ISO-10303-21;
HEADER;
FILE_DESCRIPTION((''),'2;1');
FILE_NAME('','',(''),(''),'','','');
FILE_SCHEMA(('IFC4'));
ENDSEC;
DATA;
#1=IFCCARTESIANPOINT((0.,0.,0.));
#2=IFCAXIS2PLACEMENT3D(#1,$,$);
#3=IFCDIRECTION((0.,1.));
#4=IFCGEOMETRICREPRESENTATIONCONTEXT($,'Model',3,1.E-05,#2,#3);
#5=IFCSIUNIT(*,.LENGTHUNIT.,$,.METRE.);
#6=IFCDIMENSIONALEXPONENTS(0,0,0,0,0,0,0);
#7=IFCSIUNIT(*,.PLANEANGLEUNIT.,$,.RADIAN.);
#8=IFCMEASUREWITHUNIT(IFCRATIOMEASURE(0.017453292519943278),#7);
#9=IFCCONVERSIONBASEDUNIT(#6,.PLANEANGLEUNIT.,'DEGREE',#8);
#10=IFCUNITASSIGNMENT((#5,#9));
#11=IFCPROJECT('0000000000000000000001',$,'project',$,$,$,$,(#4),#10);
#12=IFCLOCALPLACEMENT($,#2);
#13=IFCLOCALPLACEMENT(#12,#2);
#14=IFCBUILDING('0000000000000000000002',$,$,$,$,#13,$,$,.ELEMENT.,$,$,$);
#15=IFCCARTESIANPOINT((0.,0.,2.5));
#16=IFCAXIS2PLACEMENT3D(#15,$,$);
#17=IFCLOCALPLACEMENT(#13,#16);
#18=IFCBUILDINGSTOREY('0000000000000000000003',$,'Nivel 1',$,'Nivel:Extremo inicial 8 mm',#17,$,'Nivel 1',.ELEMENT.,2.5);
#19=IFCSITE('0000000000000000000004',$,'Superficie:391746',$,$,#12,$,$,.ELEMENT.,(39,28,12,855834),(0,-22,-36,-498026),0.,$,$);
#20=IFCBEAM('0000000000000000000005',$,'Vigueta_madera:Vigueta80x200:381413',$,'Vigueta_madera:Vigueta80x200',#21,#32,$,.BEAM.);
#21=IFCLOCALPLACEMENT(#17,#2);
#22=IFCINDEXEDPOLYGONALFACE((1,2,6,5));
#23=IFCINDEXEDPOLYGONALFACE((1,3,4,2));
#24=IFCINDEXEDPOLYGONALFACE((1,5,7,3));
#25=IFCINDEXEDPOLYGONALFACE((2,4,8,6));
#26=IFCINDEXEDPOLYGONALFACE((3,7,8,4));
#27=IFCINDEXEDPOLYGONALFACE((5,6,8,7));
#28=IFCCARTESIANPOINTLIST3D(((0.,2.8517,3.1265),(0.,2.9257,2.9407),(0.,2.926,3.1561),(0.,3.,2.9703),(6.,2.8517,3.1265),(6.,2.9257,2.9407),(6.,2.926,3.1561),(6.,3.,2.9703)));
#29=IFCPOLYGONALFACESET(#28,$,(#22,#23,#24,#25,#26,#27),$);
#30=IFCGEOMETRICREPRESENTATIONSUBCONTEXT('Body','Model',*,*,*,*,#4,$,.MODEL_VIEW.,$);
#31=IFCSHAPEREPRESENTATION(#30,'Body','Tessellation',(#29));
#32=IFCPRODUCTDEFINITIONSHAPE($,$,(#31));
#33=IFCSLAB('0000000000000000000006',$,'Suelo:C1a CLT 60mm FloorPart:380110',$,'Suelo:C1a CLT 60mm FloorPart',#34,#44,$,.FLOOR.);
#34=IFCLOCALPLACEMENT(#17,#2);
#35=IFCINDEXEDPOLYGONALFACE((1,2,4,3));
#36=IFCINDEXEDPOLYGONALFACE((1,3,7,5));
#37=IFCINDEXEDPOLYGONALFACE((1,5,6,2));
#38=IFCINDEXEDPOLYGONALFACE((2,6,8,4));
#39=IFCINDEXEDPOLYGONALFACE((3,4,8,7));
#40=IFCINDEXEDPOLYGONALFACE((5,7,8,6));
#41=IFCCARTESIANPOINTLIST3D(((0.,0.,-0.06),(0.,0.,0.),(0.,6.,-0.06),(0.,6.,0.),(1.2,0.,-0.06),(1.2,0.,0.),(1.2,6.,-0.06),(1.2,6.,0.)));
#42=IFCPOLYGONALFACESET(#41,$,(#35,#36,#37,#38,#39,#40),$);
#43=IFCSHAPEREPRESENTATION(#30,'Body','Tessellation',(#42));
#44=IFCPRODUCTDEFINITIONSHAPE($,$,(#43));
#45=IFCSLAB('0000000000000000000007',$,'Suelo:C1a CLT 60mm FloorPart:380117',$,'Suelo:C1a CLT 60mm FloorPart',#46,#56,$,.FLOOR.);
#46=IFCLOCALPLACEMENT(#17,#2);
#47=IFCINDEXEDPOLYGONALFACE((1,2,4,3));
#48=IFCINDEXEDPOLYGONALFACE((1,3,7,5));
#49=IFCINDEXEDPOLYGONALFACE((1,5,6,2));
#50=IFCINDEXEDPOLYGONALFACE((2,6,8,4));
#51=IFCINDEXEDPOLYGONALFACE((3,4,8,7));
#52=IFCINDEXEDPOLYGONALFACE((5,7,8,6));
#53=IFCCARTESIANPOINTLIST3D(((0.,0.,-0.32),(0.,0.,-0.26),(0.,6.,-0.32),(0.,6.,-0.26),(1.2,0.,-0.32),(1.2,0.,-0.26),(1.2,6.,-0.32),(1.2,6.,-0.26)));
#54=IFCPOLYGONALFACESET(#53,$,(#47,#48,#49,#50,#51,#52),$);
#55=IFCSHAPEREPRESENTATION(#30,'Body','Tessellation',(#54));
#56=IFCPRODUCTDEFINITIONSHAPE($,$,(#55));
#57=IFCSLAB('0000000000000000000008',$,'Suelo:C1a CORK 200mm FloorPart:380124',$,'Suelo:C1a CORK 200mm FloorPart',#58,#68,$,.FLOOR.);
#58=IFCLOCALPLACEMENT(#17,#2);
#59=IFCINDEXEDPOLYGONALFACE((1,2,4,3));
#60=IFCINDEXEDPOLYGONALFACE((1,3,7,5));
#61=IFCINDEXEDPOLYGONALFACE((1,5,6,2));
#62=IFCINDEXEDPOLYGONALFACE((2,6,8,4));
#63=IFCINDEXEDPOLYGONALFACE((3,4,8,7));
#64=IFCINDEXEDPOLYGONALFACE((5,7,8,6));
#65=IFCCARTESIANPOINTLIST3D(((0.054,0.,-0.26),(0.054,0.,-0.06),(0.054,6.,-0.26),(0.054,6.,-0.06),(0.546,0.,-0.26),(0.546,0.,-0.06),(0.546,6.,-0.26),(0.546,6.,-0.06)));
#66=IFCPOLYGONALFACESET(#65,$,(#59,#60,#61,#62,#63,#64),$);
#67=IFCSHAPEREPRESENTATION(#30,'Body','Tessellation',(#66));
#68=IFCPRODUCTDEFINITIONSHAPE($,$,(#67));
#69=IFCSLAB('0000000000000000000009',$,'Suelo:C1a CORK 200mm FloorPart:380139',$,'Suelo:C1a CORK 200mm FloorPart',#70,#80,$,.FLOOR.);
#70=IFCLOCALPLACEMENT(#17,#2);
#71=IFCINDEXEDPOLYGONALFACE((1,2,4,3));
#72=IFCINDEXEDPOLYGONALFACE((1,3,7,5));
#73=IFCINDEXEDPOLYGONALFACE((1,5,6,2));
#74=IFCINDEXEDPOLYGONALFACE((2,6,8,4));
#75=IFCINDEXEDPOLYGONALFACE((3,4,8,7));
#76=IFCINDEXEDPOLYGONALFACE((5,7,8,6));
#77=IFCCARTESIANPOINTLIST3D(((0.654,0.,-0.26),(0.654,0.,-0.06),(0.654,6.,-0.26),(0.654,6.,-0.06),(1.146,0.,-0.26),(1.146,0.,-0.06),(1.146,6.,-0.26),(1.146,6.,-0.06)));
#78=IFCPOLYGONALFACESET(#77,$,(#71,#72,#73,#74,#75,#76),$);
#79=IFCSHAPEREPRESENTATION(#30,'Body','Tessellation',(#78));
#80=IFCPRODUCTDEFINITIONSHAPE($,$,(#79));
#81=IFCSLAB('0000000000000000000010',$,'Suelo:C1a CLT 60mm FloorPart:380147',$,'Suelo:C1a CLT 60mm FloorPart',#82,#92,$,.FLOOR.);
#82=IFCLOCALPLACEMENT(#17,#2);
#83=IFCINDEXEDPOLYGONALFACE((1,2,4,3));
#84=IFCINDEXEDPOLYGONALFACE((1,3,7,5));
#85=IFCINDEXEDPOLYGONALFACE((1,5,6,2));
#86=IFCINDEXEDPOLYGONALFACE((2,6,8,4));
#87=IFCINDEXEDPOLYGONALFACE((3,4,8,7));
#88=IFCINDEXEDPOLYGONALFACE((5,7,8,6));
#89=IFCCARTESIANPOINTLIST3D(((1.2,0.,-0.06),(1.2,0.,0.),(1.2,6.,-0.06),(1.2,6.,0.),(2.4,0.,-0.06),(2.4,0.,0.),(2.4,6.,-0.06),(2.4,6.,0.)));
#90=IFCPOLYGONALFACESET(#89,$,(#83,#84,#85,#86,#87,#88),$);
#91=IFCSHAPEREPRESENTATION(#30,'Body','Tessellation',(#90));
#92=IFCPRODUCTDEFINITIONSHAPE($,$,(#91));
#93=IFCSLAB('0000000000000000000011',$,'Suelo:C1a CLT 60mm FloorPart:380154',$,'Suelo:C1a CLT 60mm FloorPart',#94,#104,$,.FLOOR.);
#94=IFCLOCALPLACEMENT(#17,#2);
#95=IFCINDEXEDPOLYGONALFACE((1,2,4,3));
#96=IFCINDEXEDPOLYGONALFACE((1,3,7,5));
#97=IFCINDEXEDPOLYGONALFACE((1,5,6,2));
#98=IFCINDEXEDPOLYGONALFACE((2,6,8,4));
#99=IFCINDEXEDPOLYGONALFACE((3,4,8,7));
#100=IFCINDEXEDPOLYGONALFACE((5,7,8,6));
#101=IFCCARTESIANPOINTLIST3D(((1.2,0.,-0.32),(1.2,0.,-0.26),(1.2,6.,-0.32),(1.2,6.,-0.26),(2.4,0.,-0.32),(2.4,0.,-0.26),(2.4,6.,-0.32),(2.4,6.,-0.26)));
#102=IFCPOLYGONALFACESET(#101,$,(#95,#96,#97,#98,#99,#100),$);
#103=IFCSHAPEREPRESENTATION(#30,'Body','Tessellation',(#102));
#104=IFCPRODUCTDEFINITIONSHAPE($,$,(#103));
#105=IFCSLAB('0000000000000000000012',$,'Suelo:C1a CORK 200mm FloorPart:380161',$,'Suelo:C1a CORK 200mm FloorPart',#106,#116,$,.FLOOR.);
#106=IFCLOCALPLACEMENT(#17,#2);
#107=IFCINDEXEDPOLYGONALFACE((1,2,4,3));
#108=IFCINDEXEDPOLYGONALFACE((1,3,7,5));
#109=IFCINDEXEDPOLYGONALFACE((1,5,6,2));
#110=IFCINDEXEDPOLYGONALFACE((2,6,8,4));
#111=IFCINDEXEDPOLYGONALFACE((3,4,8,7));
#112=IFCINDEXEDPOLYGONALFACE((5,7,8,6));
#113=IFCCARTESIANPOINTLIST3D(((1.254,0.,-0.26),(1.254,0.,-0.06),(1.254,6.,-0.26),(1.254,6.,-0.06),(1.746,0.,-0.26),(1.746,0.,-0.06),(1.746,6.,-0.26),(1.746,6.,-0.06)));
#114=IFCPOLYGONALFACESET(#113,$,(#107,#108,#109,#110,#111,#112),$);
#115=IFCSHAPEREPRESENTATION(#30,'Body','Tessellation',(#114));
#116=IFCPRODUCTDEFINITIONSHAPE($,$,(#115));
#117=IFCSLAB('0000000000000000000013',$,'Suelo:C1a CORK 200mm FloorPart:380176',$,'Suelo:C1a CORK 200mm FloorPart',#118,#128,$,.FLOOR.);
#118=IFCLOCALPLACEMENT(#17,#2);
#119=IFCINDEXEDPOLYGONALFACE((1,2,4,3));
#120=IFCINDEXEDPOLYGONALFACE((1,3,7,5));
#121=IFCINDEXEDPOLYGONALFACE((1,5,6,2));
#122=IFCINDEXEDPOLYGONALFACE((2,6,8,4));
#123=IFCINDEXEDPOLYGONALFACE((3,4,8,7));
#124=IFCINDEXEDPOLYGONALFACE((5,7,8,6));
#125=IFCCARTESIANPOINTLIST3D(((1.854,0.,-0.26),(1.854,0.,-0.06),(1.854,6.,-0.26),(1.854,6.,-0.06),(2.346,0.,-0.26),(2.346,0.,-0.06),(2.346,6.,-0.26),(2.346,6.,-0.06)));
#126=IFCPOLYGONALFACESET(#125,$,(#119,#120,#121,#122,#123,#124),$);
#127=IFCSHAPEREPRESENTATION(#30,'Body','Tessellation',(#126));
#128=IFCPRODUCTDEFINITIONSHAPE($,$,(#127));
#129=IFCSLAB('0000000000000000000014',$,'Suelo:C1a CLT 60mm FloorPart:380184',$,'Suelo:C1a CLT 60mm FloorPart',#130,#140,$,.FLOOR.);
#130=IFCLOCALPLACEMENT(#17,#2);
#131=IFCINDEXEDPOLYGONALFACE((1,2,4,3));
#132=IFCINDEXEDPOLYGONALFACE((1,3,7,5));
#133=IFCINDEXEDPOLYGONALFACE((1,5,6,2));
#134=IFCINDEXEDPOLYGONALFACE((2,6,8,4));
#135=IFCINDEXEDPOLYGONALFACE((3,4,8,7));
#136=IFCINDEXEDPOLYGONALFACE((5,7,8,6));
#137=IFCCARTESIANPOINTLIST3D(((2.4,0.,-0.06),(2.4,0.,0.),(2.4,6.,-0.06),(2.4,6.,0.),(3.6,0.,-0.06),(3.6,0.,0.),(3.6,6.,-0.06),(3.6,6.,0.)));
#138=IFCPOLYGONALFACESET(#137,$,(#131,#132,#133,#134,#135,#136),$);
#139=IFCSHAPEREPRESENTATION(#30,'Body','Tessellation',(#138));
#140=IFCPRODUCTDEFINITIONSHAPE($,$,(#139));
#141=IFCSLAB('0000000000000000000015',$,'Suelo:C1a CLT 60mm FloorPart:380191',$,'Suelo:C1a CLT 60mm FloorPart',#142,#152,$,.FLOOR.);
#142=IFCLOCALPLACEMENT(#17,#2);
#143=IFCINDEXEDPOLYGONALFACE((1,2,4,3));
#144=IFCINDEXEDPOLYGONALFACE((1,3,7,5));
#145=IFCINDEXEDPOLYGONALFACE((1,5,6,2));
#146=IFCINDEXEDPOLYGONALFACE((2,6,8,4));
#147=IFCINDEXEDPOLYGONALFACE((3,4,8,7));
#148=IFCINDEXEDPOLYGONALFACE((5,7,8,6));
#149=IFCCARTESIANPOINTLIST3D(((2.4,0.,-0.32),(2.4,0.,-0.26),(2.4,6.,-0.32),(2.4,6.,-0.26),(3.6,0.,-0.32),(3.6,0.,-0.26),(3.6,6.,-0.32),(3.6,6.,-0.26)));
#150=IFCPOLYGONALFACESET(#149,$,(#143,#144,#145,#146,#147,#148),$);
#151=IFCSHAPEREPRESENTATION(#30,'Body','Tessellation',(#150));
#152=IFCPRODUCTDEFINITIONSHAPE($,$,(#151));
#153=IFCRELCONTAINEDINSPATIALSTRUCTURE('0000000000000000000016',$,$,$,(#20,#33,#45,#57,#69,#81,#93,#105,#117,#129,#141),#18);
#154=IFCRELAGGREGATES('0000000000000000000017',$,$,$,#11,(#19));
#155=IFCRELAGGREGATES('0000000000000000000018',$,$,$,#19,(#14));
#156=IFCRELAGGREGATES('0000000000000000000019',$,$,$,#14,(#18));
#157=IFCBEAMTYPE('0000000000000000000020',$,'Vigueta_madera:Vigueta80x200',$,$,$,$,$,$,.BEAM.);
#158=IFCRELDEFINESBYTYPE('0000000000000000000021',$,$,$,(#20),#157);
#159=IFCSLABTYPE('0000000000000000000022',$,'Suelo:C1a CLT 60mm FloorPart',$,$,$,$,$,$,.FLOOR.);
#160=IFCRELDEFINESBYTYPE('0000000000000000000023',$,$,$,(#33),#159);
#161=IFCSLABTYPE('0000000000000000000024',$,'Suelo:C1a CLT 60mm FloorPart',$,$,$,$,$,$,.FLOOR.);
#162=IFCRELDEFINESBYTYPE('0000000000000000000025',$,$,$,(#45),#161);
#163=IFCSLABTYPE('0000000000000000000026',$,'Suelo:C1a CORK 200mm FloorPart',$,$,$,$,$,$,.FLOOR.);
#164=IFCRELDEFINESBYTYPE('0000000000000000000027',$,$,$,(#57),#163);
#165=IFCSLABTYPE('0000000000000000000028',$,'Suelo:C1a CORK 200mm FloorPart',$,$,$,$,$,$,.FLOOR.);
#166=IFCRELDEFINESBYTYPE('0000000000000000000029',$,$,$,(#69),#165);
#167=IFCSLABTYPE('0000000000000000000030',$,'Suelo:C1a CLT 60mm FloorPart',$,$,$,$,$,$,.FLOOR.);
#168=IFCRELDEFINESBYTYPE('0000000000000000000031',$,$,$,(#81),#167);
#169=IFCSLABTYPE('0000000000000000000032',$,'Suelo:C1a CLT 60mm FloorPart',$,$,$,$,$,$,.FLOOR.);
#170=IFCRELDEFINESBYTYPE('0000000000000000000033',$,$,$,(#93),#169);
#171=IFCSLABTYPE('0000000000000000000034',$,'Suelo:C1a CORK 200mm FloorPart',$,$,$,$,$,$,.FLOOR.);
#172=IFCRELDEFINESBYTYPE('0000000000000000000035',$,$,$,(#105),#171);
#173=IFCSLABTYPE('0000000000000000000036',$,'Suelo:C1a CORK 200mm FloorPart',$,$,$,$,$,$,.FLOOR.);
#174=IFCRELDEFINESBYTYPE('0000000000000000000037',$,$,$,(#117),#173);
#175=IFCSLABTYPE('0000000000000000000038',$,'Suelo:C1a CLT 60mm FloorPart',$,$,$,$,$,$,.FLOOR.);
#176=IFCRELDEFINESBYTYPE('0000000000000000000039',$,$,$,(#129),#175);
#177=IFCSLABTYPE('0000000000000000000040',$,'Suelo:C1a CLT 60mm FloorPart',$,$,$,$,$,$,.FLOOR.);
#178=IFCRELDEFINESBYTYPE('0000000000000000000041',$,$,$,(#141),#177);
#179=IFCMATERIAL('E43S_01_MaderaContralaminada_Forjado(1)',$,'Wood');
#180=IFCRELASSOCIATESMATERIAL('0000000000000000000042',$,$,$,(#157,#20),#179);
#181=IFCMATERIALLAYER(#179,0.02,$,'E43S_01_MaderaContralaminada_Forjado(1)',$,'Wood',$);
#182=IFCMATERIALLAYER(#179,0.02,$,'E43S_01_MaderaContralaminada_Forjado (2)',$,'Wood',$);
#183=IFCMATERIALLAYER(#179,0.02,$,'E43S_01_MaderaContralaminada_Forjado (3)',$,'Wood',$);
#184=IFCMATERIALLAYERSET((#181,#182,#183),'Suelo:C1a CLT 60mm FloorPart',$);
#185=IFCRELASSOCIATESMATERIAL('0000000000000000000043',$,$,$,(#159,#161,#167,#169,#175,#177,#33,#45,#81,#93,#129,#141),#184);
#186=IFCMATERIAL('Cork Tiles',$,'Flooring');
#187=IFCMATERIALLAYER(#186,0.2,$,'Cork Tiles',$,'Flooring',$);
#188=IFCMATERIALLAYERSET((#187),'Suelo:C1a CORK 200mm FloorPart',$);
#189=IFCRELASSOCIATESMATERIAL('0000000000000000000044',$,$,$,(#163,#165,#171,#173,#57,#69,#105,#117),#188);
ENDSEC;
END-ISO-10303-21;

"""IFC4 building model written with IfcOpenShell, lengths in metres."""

from ifc_helpers import new_model, entity, si_unit, converted_unit, direction, frame, frame_2d, origin, origin_2d_with_axis, place, context, subcontext, project, spatial, polyline, segment, composite_curve, rectangle, outline, extrude, source, transform, mapped, material, layer, layer_set, layer_usage, material_profile, profile_set, profile_usage, type_object, type_shapes, element, save


model = new_model("IFC4")

# Units and contexts
model_context = context("Model", 3, precision=1e-05, world=origin(), true_north=direction((0.0, 1.0)))
body_context = subcontext(model_context, "Body", "Model", "MODEL_VIEW")
ifc_project = project(units=[si_unit("LENGTHUNIT", "METRE"), converted_unit("PLANEANGLEUNIT", "DEGREE", entity("IfcRatioMeasure", 0.017453292519943278), si_unit("PLANEANGLEUNIT", "RADIAN"), dimensions=[0, 0, 0, 0, 0, 0, 0])], contexts=[model_context])

# Site, building, storey
site_placement = place(None, origin())
site = spatial("IfcSite", under=ifc_project, at=site_placement, Name="Superficie:391746", CompositionType="ELEMENT", RefLatitude=(39, 28, 12, 855834), RefLongitude=(0, -22, -36, -498026), RefElevation=0.0)
building_placement = place(site_placement, origin())
building = spatial("IfcBuilding", under=site, at=building_placement, CompositionType="ELEMENT")
storey_placement = place(building_placement, frame((0.0, 0.0, 2.5)))
storey = spatial("IfcBuildingStorey", under=building, at=storey_placement, Name="Nivel 1", ObjectType="Nivel:Extremo inicial 8 mm", LongName="Nivel 1", CompositionType="ELEMENT", Elevation=2.5)

# Beam
ifc_material_1 = material(Name="E43S_01_MaderaContralaminada_Forjado(1)", Category="Wood")
ifc_material_profile_1 = material_profile(ifc_material_1, outline(composite_curve([segment(polyline([(0.04, 0.1, 0.0), (0.04, -0.1, 0.0)]), True, "CONTINUOUS"), segment(polyline([(0.04, -0.1, 0.0), (-0.04, -0.1, 0.0)]), True, "CONTINUOUS"), segment(polyline([(-0.04, -0.1, 0.0), (-0.04, 0.1, 0.0)]), True, "CONTINUOUS"), segment(polyline([(-0.04, 0.1, 0.0), (0.04, 0.1, 0.0)]), True, "CONTINUOUS")], self_intersect=False), kind="CURVE"), Name="Vigueta80x200")
ifc_material_profile_2 = material_profile(ifc_material_1, outline(composite_curve([segment(polyline([(-3.0, 0.04, 0.1), (-3.0, 0.04, -0.1)]), True, "CONTINUOUS"), segment(polyline([(-3.0, 0.04, -0.1), (-3.0, -0.04, -0.1)]), True, "CONTINUOUS"), segment(polyline([(-3.0, -0.04, -0.1), (-3.0, -0.04, 0.1)]), True, "CONTINUOUS"), segment(polyline([(-3.0, -0.04, 0.1), (-3.0, 0.04, 0.1)]), True, "CONTINUOUS")], self_intersect=False), kind="CURVE"), Name="Vigueta80x200")
ifc_profile_set_1 = profile_set([ifc_material_profile_1, ifc_material_profile_2], Name="Vigueta80x200")
ifc_profile_usage_1 = profile_usage(ifc_profile_set_1, cardinal=8)
beam_type_1 = type_object("IfcBeamType", Name="Vigueta_madera:Vigueta80x200", PredefinedType="BEAM", material=ifc_profile_set_1)
shared_shape_1 = source(origin(), body_context, "Body", "SweptSolid", [
    extrude(rectangle(XDim=0.2, YDim=0.08, at=frame_2d((0.0, 0.0), x_axis=(1.0, 0.0))), frame((-3.0, 0.0, 0.0), z_axis=(1.0, 0.0, 0.0), x_axis=(0.0, 0.0, -1.0)), (0.0, 0.0, 1.0), 6.0),
])
type_shapes(beam_type_1, [shared_shape_1])
beam_1_placement = place(storey_placement, frame((3.0, 2.9258, 3.0484), z_axis=(0.0, -0.370233, 0.928939), x_axis=(1.0, 0.0, 0.0)))
element("IfcBeam", 1, at=beam_1_placement, inside=storey, type_object=beam_type_1, material=ifc_profile_usage_1, Name="Vigueta_madera:Vigueta80x200:381413", ObjectType="Vigueta_madera:Vigueta80x200", PredefinedType="BEAM", context=body_context, shape_type="MappedRepresentation", body=[
    mapped(shared_shape_1, transform((0.0, 0.0, 0.0), scale=1.0)),
])

# Slabs
ifc_layer_1 = layer(ifc_material_1, 0.02, Name="E43S_01_MaderaContralaminada_Forjado(1)", Category="Wood")
ifc_layer_2 = layer(ifc_material_1, 0.02, Name="E43S_01_MaderaContralaminada_Forjado (2)", Category="Wood")
ifc_layer_3 = layer(ifc_material_1, 0.02, Name="E43S_01_MaderaContralaminada_Forjado (3)", Category="Wood")
ifc_layer_set_1 = layer_set([ifc_layer_1, ifc_layer_2, ifc_layer_3], Name="Suelo:C1a CLT 60mm FloorPart")
ifc_layer_usage_1 = layer_usage(ifc_layer_set_1, "AXIS3", "POSITIVE", 0.0)
slab_type_1 = type_object("IfcSlabType", Name="Suelo:C1a CLT 60mm FloorPart", PredefinedType="FLOOR", material=ifc_layer_set_1)
slab_1_placement = place(storey_placement, origin())
element("IfcSlab", 2, at=slab_1_placement, inside=storey, type_object=slab_type_1, material=ifc_layer_usage_1, Name="Suelo:C1a CLT 60mm FloorPart:380110", ObjectType="Suelo:C1a CLT 60mm FloorPart", PredefinedType="FLOOR", context=body_context, shape_type="SweptSolid", body=[
    extrude(rectangle(XDim=6.0, YDim=1.2, at=origin_2d_with_axis()), frame((0.6, 3.0, 0.0), z_axis=(0.0, 0.0, -1.0), x_axis=(0.0, 1.0, 0.0)), (0.0, 0.0, 1.0), 0.06),
])
ifc_layer_usage_2 = layer_usage(ifc_layer_set_1, "AXIS3", "POSITIVE", 0.0)
slab_type_2 = type_object("IfcSlabType", Name="Suelo:C1a CLT 60mm FloorPart", PredefinedType="FLOOR", material=ifc_layer_set_1)
slab_2_placement = place(storey_placement, origin())
element("IfcSlab", 3, at=slab_2_placement, inside=storey, type_object=slab_type_2, material=ifc_layer_usage_2, Name="Suelo:C1a CLT 60mm FloorPart:380117", ObjectType="Suelo:C1a CLT 60mm FloorPart", PredefinedType="FLOOR", context=body_context, shape_type="SweptSolid", body=[
    extrude(rectangle(XDim=6.0, YDim=1.2, at=origin_2d_with_axis()), frame((0.6, 3.0, -0.26), z_axis=(0.0, 0.0, -1.0), x_axis=(0.0, 1.0, 0.0)), (0.0, 0.0, 1.0), 0.06),
])
ifc_material_2 = material(Name="Cork Tiles", Category="Flooring")
ifc_layer_4 = layer(ifc_material_2, 0.2, Name="Cork Tiles", Category="Flooring")
ifc_layer_set_2 = layer_set([ifc_layer_4], Name="Suelo:C1a CORK 200mm FloorPart")
ifc_layer_usage_3 = layer_usage(ifc_layer_set_2, "AXIS3", "POSITIVE", 0.0)
slab_type_3 = type_object("IfcSlabType", Name="Suelo:C1a CORK 200mm FloorPart", PredefinedType="FLOOR", material=ifc_layer_set_2)
slab_3_placement = place(storey_placement, origin())
element("IfcSlab", 4, at=slab_3_placement, inside=storey, type_object=slab_type_3, material=ifc_layer_usage_3, Name="Suelo:C1a CORK 200mm FloorPart:380124", ObjectType="Suelo:C1a CORK 200mm FloorPart", PredefinedType="FLOOR", context=body_context, shape_type="SweptSolid", body=[
    extrude(rectangle(XDim=6.0, YDim=0.492, at=origin_2d_with_axis()), frame((0.3, 3.0, -0.06), z_axis=(0.0, 0.0, -1.0), x_axis=(0.0, 1.0, 0.0)), (0.0, 0.0, 1.0), 0.2),
])
ifc_layer_usage_4 = layer_usage(ifc_layer_set_2, "AXIS3", "POSITIVE", 0.0)
slab_type_4 = type_object("IfcSlabType", Name="Suelo:C1a CORK 200mm FloorPart", PredefinedType="FLOOR", material=ifc_layer_set_2)
slab_4_placement = place(storey_placement, origin())
element("IfcSlab", 5, at=slab_4_placement, inside=storey, type_object=slab_type_4, material=ifc_layer_usage_4, Name="Suelo:C1a CORK 200mm FloorPart:380139", ObjectType="Suelo:C1a CORK 200mm FloorPart", PredefinedType="FLOOR", context=body_context, shape_type="SweptSolid", body=[
    extrude(rectangle(XDim=6.0, YDim=0.492, at=frame_2d((0.0, 0.0), x_axis=(1.0, 0.0))), frame((0.9, 3.0, -0.06), z_axis=(0.0, 0.0, -1.0), x_axis=(0.0, 1.0, 0.0)), (0.0, 0.0, 1.0), 0.2),
])
ifc_layer_usage_5 = layer_usage(ifc_layer_set_1, "AXIS3", "POSITIVE", 0.0)
slab_type_5 = type_object("IfcSlabType", Name="Suelo:C1a CLT 60mm FloorPart", PredefinedType="FLOOR", material=ifc_layer_set_1)
slab_5_placement = place(storey_placement, origin())
element("IfcSlab", 6, at=slab_5_placement, inside=storey, type_object=slab_type_5, material=ifc_layer_usage_5, Name="Suelo:C1a CLT 60mm FloorPart:380147", ObjectType="Suelo:C1a CLT 60mm FloorPart", PredefinedType="FLOOR", context=body_context, shape_type="SweptSolid", body=[
    extrude(rectangle(XDim=6.0, YDim=1.2, at=origin_2d_with_axis()), frame((1.8, 3.0, 0.0), z_axis=(0.0, 0.0, -1.0), x_axis=(0.0, 1.0, 0.0)), (0.0, 0.0, 1.0), 0.06),
])
ifc_layer_usage_6 = layer_usage(ifc_layer_set_1, "AXIS3", "POSITIVE", 0.0)
slab_type_6 = type_object("IfcSlabType", Name="Suelo:C1a CLT 60mm FloorPart", PredefinedType="FLOOR", material=ifc_layer_set_1)
slab_6_placement = place(storey_placement, origin())
element("IfcSlab", 7, at=slab_6_placement, inside=storey, type_object=slab_type_6, material=ifc_layer_usage_6, Name="Suelo:C1a CLT 60mm FloorPart:380154", ObjectType="Suelo:C1a CLT 60mm FloorPart", PredefinedType="FLOOR", context=body_context, shape_type="SweptSolid", body=[
    extrude(rectangle(XDim=6.0, YDim=1.2, at=origin_2d_with_axis()), frame((1.8, 3.0, -0.26), z_axis=(0.0, 0.0, -1.0), x_axis=(0.0, 1.0, 0.0)), (0.0, 0.0, 1.0), 0.06),
])
ifc_layer_usage_7 = layer_usage(ifc_layer_set_2, "AXIS3", "POSITIVE", 0.0)
slab_type_7 = type_object("IfcSlabType", Name="Suelo:C1a CORK 200mm FloorPart", PredefinedType="FLOOR", material=ifc_layer_set_2)
slab_7_placement = place(storey_placement, origin())
element("IfcSlab", 8, at=slab_7_placement, inside=storey, type_object=slab_type_7, material=ifc_layer_usage_7, Name="Suelo:C1a CORK 200mm FloorPart:380161", ObjectType="Suelo:C1a CORK 200mm FloorPart", PredefinedType="FLOOR", context=body_context, shape_type="SweptSolid", body=[
    extrude(rectangle(XDim=6.0, YDim=0.492, at=frame_2d((0.0, 0.0), x_axis=(1.0, 0.0))), frame((1.5, 3.0, -0.06), z_axis=(0.0, 0.0, -1.0), x_axis=(0.0, 1.0, 0.0)), (0.0, 0.0, 1.0), 0.2),
])
ifc_layer_usage_8 = layer_usage(ifc_layer_set_2, "AXIS3", "POSITIVE", 0.0)
slab_type_8 = type_object("IfcSlabType", Name="Suelo:C1a CORK 200mm FloorPart", PredefinedType="FLOOR", material=ifc_layer_set_2)
slab_8_placement = place(storey_placement, origin())
element("IfcSlab", 9, at=slab_8_placement, inside=storey, type_object=slab_type_8, material=ifc_layer_usage_8, Name="Suelo:C1a CORK 200mm FloorPart:380176", ObjectType="Suelo:C1a CORK 200mm FloorPart", PredefinedType="FLOOR", context=body_context, shape_type="SweptSolid", body=[
    extrude(rectangle(XDim=6.0, YDim=0.492, at=origin_2d_with_axis()), frame((2.1, 3.0, -0.06), z_axis=(0.0, 0.0, -1.0), x_axis=(0.0, 1.0, 0.0)), (0.0, 0.0, 1.0), 0.2),
])
ifc_layer_usage_9 = layer_usage(ifc_layer_set_1, "AXIS3", "POSITIVE", 0.0)
slab_type_9 = type_object("IfcSlabType", Name="Suelo:C1a CLT 60mm FloorPart", PredefinedType="FLOOR", material=ifc_layer_set_1)
slab_9_placement = place(storey_placement, origin())
element("IfcSlab", 10, at=slab_9_placement, inside=storey, type_object=slab_type_9, material=ifc_layer_usage_9, Name="Suelo:C1a CLT 60mm FloorPart:380184", ObjectType="Suelo:C1a CLT 60mm FloorPart", PredefinedType="FLOOR", context=body_context, shape_type="SweptSolid", body=[
    extrude(rectangle(XDim=6.0, YDim=1.2, at=origin_2d_with_axis()), frame((3.0, 3.0, 0.0), z_axis=(0.0, 0.0, -1.0), x_axis=(0.0, 1.0, 0.0)), (0.0, 0.0, 1.0), 0.06),
])
ifc_layer_usage_10 = layer_usage(ifc_layer_set_1, "AXIS3", "POSITIVE", 0.0)
slab_type_10 = type_object("IfcSlabType", Name="Suelo:C1a CLT 60mm FloorPart", PredefinedType="FLOOR", material=ifc_layer_set_1)
slab_10_placement = place(storey_placement, origin())
element("IfcSlab", 11, at=slab_10_placement, inside=storey, type_object=slab_type_10, material=ifc_layer_usage_10, Name="Suelo:C1a CLT 60mm FloorPart:380191", ObjectType="Suelo:C1a CLT 60mm FloorPart", PredefinedType="FLOOR", context=body_context, shape_type="SweptSolid", body=[
    extrude(rectangle(XDim=6.0, YDim=1.2, at=origin_2d_with_axis()), frame((3.0, 3.0, -0.26), z_axis=(0.0, 0.0, -1.0), x_axis=(0.0, 1.0, 0.0)), (0.0, 0.0, 1.0), 0.06),
])

save(model, "model.ifc")
